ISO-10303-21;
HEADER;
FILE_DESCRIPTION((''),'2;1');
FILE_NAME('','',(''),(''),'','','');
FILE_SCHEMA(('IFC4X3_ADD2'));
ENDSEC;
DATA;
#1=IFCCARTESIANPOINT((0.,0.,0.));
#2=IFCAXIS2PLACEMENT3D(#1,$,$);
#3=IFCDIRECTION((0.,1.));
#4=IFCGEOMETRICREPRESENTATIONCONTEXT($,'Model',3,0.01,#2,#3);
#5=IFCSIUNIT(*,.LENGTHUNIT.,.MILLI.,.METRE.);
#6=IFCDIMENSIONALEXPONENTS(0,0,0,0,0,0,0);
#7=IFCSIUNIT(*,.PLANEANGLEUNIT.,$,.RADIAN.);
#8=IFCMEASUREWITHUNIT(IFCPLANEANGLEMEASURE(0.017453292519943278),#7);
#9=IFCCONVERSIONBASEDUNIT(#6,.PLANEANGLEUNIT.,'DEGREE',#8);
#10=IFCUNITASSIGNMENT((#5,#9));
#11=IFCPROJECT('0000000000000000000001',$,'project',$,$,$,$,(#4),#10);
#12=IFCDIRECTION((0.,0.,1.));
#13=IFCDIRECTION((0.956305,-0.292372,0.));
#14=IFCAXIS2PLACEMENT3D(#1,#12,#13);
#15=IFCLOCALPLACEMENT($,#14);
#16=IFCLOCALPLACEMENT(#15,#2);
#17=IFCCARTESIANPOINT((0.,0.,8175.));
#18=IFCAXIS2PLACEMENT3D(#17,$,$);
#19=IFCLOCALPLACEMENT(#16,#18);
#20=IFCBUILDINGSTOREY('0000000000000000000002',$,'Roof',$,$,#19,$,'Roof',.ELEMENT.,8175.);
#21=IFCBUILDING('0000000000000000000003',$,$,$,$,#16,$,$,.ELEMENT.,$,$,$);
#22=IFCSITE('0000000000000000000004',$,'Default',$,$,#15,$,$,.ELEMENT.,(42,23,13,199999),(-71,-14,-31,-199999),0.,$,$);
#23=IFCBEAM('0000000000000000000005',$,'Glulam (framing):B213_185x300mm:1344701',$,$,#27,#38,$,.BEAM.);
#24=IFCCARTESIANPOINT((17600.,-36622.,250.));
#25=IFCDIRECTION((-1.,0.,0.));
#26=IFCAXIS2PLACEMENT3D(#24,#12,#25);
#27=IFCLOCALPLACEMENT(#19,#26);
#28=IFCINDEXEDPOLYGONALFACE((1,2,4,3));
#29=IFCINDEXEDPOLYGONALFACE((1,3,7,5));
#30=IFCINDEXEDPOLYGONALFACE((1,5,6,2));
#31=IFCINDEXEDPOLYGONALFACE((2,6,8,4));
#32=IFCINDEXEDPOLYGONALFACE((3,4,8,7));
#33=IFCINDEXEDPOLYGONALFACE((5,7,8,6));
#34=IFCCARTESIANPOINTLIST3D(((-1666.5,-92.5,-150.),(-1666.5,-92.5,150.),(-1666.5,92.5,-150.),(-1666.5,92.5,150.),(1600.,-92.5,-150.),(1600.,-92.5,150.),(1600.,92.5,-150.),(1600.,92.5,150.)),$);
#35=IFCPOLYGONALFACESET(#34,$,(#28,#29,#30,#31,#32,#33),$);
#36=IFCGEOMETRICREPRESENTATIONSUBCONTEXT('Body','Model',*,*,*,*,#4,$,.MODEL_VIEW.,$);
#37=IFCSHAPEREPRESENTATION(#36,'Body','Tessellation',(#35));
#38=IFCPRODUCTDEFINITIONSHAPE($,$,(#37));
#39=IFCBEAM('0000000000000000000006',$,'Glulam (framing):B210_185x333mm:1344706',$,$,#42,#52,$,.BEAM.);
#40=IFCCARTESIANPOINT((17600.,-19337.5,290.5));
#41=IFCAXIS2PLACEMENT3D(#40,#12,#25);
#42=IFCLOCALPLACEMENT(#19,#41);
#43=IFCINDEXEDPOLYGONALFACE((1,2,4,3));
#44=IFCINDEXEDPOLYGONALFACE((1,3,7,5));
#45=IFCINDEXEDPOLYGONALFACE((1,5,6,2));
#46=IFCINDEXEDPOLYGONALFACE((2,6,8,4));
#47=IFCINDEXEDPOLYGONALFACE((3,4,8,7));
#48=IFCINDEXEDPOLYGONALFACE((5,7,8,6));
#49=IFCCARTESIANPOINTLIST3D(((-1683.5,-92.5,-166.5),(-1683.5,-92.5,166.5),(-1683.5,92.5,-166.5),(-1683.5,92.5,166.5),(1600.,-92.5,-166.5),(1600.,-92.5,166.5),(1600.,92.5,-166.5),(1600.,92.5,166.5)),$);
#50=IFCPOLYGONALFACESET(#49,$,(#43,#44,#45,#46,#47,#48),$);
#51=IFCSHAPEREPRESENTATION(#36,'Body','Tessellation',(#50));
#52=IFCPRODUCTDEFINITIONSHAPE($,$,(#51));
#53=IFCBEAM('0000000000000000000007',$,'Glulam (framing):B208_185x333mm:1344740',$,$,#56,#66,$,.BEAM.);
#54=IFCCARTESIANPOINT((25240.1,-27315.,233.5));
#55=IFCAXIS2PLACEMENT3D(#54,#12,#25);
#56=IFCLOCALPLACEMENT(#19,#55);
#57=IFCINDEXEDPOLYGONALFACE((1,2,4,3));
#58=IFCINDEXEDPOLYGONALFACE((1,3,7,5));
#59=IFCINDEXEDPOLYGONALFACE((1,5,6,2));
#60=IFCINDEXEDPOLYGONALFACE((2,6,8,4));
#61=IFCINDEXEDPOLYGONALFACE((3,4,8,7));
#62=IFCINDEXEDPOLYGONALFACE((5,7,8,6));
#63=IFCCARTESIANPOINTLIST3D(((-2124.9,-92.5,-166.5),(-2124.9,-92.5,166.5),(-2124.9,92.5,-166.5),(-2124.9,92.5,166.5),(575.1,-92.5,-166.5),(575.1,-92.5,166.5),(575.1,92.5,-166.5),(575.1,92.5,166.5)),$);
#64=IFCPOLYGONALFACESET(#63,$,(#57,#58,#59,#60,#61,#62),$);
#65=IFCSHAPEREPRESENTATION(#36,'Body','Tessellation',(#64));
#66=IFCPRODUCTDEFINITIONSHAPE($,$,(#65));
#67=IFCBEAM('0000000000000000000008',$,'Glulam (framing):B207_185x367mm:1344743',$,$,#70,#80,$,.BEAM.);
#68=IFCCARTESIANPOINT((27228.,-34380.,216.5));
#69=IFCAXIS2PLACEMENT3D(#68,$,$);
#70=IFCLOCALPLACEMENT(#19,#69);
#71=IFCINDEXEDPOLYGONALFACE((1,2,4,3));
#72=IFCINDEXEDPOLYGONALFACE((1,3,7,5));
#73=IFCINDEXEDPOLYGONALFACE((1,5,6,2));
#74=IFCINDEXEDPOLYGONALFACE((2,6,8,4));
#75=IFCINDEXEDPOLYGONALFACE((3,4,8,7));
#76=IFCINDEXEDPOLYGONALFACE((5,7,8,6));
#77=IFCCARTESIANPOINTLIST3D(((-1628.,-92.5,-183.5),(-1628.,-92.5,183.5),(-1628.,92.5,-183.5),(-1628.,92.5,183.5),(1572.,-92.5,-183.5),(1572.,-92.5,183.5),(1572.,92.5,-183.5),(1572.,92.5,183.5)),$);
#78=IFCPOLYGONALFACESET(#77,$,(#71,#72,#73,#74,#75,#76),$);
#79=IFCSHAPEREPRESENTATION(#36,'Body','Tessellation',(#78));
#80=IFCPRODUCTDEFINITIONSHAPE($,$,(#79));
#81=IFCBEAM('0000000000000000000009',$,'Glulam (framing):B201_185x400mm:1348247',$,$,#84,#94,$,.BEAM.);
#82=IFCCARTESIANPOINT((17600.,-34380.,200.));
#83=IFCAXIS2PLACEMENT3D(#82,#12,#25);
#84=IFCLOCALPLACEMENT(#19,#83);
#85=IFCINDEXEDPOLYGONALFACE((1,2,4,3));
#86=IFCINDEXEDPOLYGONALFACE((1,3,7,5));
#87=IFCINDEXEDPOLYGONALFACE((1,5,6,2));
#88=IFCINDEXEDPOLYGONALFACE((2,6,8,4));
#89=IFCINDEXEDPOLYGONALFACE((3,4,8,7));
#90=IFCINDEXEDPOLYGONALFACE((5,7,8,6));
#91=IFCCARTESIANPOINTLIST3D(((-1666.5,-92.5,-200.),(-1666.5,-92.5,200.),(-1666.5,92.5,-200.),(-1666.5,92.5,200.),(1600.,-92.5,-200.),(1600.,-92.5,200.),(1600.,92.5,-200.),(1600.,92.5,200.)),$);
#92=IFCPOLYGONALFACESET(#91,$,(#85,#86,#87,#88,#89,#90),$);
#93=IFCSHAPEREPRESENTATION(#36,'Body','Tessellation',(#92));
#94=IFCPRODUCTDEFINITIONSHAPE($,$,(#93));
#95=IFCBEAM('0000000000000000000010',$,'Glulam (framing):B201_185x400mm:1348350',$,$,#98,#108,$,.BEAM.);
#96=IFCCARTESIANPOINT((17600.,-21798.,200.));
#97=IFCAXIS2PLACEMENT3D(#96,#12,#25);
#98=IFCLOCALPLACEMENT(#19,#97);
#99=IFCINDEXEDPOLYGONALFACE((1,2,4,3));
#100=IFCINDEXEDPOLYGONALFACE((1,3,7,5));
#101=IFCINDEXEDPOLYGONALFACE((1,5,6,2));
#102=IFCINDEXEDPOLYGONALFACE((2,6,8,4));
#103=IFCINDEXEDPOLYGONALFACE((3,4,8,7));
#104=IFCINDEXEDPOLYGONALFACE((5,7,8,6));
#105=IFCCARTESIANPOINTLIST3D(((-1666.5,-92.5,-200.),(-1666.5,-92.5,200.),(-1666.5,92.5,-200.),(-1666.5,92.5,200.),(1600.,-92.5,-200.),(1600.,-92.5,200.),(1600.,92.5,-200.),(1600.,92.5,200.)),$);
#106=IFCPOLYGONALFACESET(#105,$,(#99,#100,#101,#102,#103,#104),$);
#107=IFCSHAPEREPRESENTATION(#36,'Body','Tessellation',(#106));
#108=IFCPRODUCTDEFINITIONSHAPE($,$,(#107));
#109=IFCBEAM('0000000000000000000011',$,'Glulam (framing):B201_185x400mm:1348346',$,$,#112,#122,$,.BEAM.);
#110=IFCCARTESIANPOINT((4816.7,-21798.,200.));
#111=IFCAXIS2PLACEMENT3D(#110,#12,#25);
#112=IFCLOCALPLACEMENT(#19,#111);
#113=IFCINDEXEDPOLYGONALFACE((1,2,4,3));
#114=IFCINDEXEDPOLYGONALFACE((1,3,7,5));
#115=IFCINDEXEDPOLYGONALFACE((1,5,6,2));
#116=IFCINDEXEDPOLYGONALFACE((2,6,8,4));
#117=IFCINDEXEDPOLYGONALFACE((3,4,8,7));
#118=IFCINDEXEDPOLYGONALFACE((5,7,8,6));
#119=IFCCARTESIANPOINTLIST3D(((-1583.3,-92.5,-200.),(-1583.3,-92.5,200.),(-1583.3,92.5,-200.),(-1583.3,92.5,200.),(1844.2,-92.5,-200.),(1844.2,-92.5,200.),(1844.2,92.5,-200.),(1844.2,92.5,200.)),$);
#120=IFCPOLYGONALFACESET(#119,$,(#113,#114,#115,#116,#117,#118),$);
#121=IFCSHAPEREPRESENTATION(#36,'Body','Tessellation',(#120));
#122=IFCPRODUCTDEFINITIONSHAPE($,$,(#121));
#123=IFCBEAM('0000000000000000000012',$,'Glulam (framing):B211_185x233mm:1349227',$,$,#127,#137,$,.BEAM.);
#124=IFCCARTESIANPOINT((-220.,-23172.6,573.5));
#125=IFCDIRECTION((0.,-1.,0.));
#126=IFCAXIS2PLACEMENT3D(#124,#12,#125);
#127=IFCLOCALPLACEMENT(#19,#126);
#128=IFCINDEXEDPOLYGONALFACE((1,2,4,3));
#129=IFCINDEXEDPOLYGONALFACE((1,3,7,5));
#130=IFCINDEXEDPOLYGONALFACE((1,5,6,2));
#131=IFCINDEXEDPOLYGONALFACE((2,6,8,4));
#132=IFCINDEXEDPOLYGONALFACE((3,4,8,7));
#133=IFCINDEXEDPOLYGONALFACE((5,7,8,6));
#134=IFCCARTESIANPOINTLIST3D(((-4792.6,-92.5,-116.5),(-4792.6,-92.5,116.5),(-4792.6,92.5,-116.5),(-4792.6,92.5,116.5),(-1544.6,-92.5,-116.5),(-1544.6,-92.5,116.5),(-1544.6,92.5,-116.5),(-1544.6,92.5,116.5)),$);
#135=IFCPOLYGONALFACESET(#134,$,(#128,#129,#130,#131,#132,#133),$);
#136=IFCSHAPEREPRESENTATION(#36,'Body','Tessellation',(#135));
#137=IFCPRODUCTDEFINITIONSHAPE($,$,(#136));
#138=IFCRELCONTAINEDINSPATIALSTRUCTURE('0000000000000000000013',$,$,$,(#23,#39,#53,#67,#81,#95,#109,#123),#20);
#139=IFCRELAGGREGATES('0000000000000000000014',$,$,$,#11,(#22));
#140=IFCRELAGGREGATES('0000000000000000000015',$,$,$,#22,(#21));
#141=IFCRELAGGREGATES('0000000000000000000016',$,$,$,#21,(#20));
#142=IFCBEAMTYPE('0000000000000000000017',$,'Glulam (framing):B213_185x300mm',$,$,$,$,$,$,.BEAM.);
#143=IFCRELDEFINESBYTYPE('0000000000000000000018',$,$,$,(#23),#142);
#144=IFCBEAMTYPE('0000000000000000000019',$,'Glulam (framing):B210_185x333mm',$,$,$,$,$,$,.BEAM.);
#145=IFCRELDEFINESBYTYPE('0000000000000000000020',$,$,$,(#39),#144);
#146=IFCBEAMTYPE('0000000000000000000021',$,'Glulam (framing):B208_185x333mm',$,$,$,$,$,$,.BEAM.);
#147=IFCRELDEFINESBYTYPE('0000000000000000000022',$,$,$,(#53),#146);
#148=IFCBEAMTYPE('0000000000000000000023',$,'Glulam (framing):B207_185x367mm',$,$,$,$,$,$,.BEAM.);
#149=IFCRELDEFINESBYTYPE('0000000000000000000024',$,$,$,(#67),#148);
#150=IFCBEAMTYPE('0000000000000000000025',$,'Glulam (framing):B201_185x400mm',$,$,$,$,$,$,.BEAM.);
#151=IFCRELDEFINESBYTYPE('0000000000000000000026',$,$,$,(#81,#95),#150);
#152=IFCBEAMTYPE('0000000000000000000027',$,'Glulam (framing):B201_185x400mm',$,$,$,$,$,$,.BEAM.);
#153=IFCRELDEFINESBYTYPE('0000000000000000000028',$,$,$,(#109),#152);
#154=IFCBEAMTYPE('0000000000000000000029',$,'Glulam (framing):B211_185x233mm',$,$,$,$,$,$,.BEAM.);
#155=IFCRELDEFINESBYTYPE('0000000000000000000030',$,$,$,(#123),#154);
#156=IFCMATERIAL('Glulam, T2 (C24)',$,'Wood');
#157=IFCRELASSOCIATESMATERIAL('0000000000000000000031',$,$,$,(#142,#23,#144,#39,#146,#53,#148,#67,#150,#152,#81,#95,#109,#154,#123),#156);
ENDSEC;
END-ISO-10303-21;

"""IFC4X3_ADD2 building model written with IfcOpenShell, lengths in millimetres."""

from ifc_helpers import new_model, entity, si_unit, converted_unit, direction, frame, frame_2d, origin, origin_2d_with_axis, place, context, subcontext, project, spatial, rectangle, extrude, source, transform, mapped, material, material_profile, profile_set, profile_usage, type_object, type_shapes, element, save


model = new_model("IFC4X3_ADD2")

# Units and contexts
model_context = context("Model", 3, precision=0.01, world=origin(), true_north=direction((0.0, 1.0)))
body_context = subcontext(model_context, "Body", "Model", "MODEL_VIEW")
ifc_project = project(units=[si_unit("LENGTHUNIT", "METRE", prefix="MILLI"), converted_unit("PLANEANGLEUNIT", "DEGREE", entity("IfcPlaneAngleMeasure", 0.017453292519943278), si_unit("PLANEANGLEUNIT", "RADIAN"), dimensions=[0, 0, 0, 0, 0, 0, 0])], contexts=[model_context])

# Site, building, storey
site_placement = place(None, frame((0.0, 0.0, 0.0), z_axis=(0.0, 0.0, 1.0), x_axis=(0.956305, -0.292372, 0.0)))
site = spatial("IfcSite", under=ifc_project, at=site_placement, Name="Default", CompositionType="ELEMENT", RefLatitude=(42, 23, 13, 199999), RefLongitude=(-71, -14, -31, -199999), RefElevation=0.0)
building_placement = place(site_placement, origin())
building = spatial("IfcBuilding", under=site, at=building_placement, CompositionType="ELEMENT")
storey_placement = place(building_placement, frame((0.0, 0.0, 8175.0)))
storey = spatial("IfcBuildingStorey", under=building, at=storey_placement, Name="Roof", LongName="Roof", CompositionType="ELEMENT", Elevation=8175.0)

# Beams
ifc_material = material(Name="Glulam, T2 (C24)", Category="Wood")
ifc_material_profile_1 = material_profile(ifc_material, rectangle(XDim=3200.0, YDim=185.0, at=origin_2d_with_axis()), Name="B213_185x300mm")
ifc_profile_set_1 = profile_set([ifc_material_profile_1], Name="B213_185x300mm")
ifc_profile_usage_1 = profile_usage(ifc_profile_set_1, cardinal=8)
beam_type_1 = type_object("IfcBeamType", Name="Glulam (framing):B213_185x300mm", PredefinedType="BEAM", material=ifc_profile_set_1)
shared_shape_1 = source(origin(), body_context, "Body", "SweptSolid", [
    extrude(rectangle(XDim=3266.5, YDim=185.0, at=origin_2d_with_axis()), frame((-33.2, 0.0, -150.0), z_axis=(0.0, 0.0, 1.0), x_axis=(-1.0, 0.0, 0.0)), (0.0, 0.0, 1.0), 300.0),
])
type_shapes(beam_type_1, [shared_shape_1])
beam_1_placement = place(storey_placement, frame((17600.0, -36622.0, 250.0), z_axis=(0.0, 0.0, 1.0), x_axis=(-1.0, 0.0, 0.0)))
element("IfcBeam", 1, at=beam_1_placement, inside=storey, type_object=beam_type_1, material=ifc_profile_usage_1, Name="Glulam (framing):B213_185x300mm:1344701", PredefinedType="BEAM", context=body_context, shape_type="MappedRepresentation", body=[
    mapped(shared_shape_1, transform((0.0, 0.0, 0.0), scale=1.0)),
])
ifc_material_profile_2 = material_profile(ifc_material, rectangle(XDim=185.0, YDim=3200.0, at=origin_2d_with_axis()), Name="B210_185x333mm")
ifc_profile_set_2 = profile_set([ifc_material_profile_2], Name="B210_185x333mm")
ifc_profile_usage_2 = profile_usage(ifc_profile_set_2, cardinal=8)
beam_type_2 = type_object("IfcBeamType", Name="Glulam (framing):B210_185x333mm", PredefinedType="BEAM", material=ifc_profile_set_2)
shared_shape_2 = source(origin(), body_context, "Body", "SweptSolid", [
    extrude(rectangle(XDim=185.0, YDim=3283.5, at=origin_2d_with_axis()), frame((-41.7, 0.0, -166.5), z_axis=(0.0, 0.0, 1.0), x_axis=(0.0, 1.0, 0.0)), (0.0, 0.0, 1.0), 333.0),
])
type_shapes(beam_type_2, [shared_shape_2])
beam_2_placement = place(storey_placement, frame((17600.0, -19337.5, 290.5), z_axis=(0.0, 0.0, 1.0), x_axis=(-1.0, 0.0, 0.0)))
element("IfcBeam", 2, at=beam_2_placement, inside=storey, type_object=beam_type_2, material=ifc_profile_usage_2, Name="Glulam (framing):B210_185x333mm:1344706", PredefinedType="BEAM", context=body_context, shape_type="MappedRepresentation", body=[
    mapped(shared_shape_2, transform((0.0, 0.0, 0.0), scale=1.0)),
])
ifc_material_profile_3 = material_profile(ifc_material, rectangle(XDim=3200.0, YDim=185.0, at=origin_2d_with_axis()), Name="B211_185x233mm")
ifc_profile_set_3 = profile_set([ifc_material_profile_3], Name="B211_185x233mm")
ifc_profile_usage_3 = profile_usage(ifc_profile_set_3, cardinal=8)
ifc_material_profile_4 = material_profile(ifc_material, rectangle(XDim=2161.0, YDim=185.0, at=origin_2d_with_axis()), Name="B208_185x333mm")
ifc_profile_set_4 = profile_set([ifc_material_profile_4], Name="B208_185x333mm")
ifc_profile_usage_4 = profile_usage(ifc_profile_set_4, cardinal=8)
beam_type_3 = type_object("IfcBeamType", Name="Glulam (framing):B208_185x333mm", PredefinedType="BEAM", material=ifc_profile_set_4)
shared_shape_3 = source(origin(), body_context, "Body", "SweptSolid", [
    extrude(rectangle(XDim=185.0, YDim=2700.0, at=origin_2d_with_axis()), frame((-774.9, 0.0, -166.5), z_axis=(0.0, 0.0, 1.0), x_axis=(0.0, 1.0, 0.0)), (0.0, 0.0, 1.0), 333.0),
])
type_shapes(beam_type_3, [shared_shape_3])
beam_3_placement = place(storey_placement, frame((25240.1, -27315.0, 233.5), z_axis=(0.0, 0.0, 1.0), x_axis=(-1.0, 0.0, 0.0)))
element("IfcBeam", 3, at=beam_3_placement, inside=storey, type_object=beam_type_3, material=ifc_profile_usage_4, Name="Glulam (framing):B208_185x333mm:1344740", PredefinedType="BEAM", context=body_context, shape_type="MappedRepresentation", body=[
    mapped(shared_shape_3, transform((0.0, 0.0, 0.0), scale=1.0)),
])
ifc_material_profile_5 = material_profile(ifc_material, rectangle(XDim=3140.0, YDim=185.0, at=origin_2d_with_axis()), Name="B207_185x367mm")
ifc_profile_set_5 = profile_set([ifc_material_profile_5], Name="B207_185x367mm")
ifc_profile_usage_5 = profile_usage(ifc_profile_set_5, cardinal=8)
beam_type_4 = type_object("IfcBeamType", Name="Glulam (framing):B207_185x367mm", PredefinedType="BEAM", material=ifc_profile_set_5)
shared_shape_4 = source(origin(), body_context, "Body", "SweptSolid", [
    extrude(rectangle(XDim=3200.0, YDim=185.0, at=origin_2d_with_axis()), frame((-28.0, 0.0, -183.5), z_axis=(0.0, 0.0, 1.0), x_axis=(-1.0, 0.0, 0.0)), (0.0, 0.0, 1.0), 367.0),
])
type_shapes(beam_type_4, [shared_shape_4])
beam_4_placement = place(storey_placement, frame((27228.0, -34380.0, 216.5)))
element("IfcBeam", 4, at=beam_4_placement, inside=storey, type_object=beam_type_4, material=ifc_profile_usage_5, Name="Glulam (framing):B207_185x367mm:1344743", PredefinedType="BEAM", context=body_context, shape_type="MappedRepresentation", body=[
    mapped(shared_shape_4, transform((0.0, 0.0, 0.0), scale=1.0)),
])
ifc_material_profile_6 = material_profile(ifc_material, rectangle(XDim=3335.0, YDim=185.0, at=origin_2d_with_axis()), Name="B201_185x400mm")
ifc_profile_set_6 = profile_set([ifc_material_profile_6], Name="B201_185x400mm")
ifc_profile_usage_6 = profile_usage(ifc_profile_set_6, cardinal=8)
beam_type_5 = type_object("IfcBeamType", Name="Glulam (framing):B201_185x400mm", PredefinedType="BEAM", material=ifc_profile_set_6)
shared_shape_5 = source(origin(), body_context, "Body", "SweptSolid", [
    extrude(rectangle(XDim=3266.5, YDim=185.0, at=origin_2d_with_axis()), frame((-33.2, 0.0, -200.0), z_axis=(0.0, 0.0, 1.0), x_axis=(-1.0, 0.0, 0.0)), (0.0, 0.0, 1.0), 400.0),
])
type_shapes(beam_type_5, [shared_shape_5])
for number, where, z_axis, x_axis, name in (
    (5, (17600.0, -34380.0, 200.0), (0.0, 0.0, 1.0), (-1.0, 0.0, 0.0), "Glulam (framing):B201_185x400mm:1348247"),
    (6, (17600.0, -21798.0, 200.0), (0.0, 0.0, 1.0), (-1.0, 0.0, 0.0), "Glulam (framing):B201_185x400mm:1348350"),
):
    element("IfcBeam", number, at=place(storey_placement, frame(where, z_axis=z_axis, x_axis=x_axis)), inside=storey, type_object=beam_type_5, material=ifc_profile_usage_6, Name=name, PredefinedType="BEAM", context=body_context, shape_type="MappedRepresentation", body=[
        mapped(shared_shape_5, transform((0.0, 0.0, 0.0), scale=1.0)),
    ])
beam_type_6 = type_object("IfcBeamType", Name="Glulam (framing):B201_185x400mm", PredefinedType="BEAM", material=ifc_profile_set_6)
shared_shape_6 = source(origin(), body_context, "Body", "SweptSolid", [
    extrude(rectangle(XDim=3427.5, YDim=185.0, at=origin_2d_with_axis()), frame((130.5, 0.0, -200.0), z_axis=(0.0, 0.0, 1.0), x_axis=(-1.0, 0.0, 0.0)), (0.0, 0.0, 1.0), 400.0),
])
type_shapes(beam_type_6, [shared_shape_6])
beam_5_placement = place(storey_placement, frame((4816.7, -21798.0, 200.0), z_axis=(0.0, 0.0, 1.0), x_axis=(-1.0, 0.0, 0.0)))
element("IfcBeam", 7, at=beam_5_placement, inside=storey, type_object=beam_type_6, material=ifc_profile_usage_6, Name="Glulam (framing):B201_185x400mm:1348346", PredefinedType="BEAM", context=body_context, shape_type="MappedRepresentation", body=[
    mapped(shared_shape_6, transform((0.0, 0.0, 0.0), scale=1.0)),
])
beam_type_7 = type_object("IfcBeamType", Name="Glulam (framing):B211_185x233mm", PredefinedType="BEAM", material=ifc_profile_set_3)
shared_shape_7 = source(origin(), body_context, "Body", "SweptSolid", [
    extrude(rectangle(XDim=3248.0, YDim=185.0, at=frame_2d((0.0, 0.0), x_axis=(1.0, 0.0))), frame((-3168.6, 0.0, -116.5), z_axis=(0.0, 0.0, 1.0), x_axis=(-1.0, 0.0, 0.0)), (0.0, 0.0, 1.0), 233.0),
])
type_shapes(beam_type_7, [shared_shape_7])
beam_6_placement = place(storey_placement, frame((-220.0, -23172.6, 573.5), z_axis=(0.0, 0.0, 1.0), x_axis=(0.0, -1.0, 0.0)))
element("IfcBeam", 8, at=beam_6_placement, inside=storey, type_object=beam_type_7, material=ifc_profile_usage_3, Name="Glulam (framing):B211_185x233mm:1349227", PredefinedType="BEAM", context=body_context, shape_type="MappedRepresentation", body=[
    mapped(shared_shape_7, transform((0.0, 0.0, 0.0), scale=1.0)),
])

save(model, "model.ifc")
